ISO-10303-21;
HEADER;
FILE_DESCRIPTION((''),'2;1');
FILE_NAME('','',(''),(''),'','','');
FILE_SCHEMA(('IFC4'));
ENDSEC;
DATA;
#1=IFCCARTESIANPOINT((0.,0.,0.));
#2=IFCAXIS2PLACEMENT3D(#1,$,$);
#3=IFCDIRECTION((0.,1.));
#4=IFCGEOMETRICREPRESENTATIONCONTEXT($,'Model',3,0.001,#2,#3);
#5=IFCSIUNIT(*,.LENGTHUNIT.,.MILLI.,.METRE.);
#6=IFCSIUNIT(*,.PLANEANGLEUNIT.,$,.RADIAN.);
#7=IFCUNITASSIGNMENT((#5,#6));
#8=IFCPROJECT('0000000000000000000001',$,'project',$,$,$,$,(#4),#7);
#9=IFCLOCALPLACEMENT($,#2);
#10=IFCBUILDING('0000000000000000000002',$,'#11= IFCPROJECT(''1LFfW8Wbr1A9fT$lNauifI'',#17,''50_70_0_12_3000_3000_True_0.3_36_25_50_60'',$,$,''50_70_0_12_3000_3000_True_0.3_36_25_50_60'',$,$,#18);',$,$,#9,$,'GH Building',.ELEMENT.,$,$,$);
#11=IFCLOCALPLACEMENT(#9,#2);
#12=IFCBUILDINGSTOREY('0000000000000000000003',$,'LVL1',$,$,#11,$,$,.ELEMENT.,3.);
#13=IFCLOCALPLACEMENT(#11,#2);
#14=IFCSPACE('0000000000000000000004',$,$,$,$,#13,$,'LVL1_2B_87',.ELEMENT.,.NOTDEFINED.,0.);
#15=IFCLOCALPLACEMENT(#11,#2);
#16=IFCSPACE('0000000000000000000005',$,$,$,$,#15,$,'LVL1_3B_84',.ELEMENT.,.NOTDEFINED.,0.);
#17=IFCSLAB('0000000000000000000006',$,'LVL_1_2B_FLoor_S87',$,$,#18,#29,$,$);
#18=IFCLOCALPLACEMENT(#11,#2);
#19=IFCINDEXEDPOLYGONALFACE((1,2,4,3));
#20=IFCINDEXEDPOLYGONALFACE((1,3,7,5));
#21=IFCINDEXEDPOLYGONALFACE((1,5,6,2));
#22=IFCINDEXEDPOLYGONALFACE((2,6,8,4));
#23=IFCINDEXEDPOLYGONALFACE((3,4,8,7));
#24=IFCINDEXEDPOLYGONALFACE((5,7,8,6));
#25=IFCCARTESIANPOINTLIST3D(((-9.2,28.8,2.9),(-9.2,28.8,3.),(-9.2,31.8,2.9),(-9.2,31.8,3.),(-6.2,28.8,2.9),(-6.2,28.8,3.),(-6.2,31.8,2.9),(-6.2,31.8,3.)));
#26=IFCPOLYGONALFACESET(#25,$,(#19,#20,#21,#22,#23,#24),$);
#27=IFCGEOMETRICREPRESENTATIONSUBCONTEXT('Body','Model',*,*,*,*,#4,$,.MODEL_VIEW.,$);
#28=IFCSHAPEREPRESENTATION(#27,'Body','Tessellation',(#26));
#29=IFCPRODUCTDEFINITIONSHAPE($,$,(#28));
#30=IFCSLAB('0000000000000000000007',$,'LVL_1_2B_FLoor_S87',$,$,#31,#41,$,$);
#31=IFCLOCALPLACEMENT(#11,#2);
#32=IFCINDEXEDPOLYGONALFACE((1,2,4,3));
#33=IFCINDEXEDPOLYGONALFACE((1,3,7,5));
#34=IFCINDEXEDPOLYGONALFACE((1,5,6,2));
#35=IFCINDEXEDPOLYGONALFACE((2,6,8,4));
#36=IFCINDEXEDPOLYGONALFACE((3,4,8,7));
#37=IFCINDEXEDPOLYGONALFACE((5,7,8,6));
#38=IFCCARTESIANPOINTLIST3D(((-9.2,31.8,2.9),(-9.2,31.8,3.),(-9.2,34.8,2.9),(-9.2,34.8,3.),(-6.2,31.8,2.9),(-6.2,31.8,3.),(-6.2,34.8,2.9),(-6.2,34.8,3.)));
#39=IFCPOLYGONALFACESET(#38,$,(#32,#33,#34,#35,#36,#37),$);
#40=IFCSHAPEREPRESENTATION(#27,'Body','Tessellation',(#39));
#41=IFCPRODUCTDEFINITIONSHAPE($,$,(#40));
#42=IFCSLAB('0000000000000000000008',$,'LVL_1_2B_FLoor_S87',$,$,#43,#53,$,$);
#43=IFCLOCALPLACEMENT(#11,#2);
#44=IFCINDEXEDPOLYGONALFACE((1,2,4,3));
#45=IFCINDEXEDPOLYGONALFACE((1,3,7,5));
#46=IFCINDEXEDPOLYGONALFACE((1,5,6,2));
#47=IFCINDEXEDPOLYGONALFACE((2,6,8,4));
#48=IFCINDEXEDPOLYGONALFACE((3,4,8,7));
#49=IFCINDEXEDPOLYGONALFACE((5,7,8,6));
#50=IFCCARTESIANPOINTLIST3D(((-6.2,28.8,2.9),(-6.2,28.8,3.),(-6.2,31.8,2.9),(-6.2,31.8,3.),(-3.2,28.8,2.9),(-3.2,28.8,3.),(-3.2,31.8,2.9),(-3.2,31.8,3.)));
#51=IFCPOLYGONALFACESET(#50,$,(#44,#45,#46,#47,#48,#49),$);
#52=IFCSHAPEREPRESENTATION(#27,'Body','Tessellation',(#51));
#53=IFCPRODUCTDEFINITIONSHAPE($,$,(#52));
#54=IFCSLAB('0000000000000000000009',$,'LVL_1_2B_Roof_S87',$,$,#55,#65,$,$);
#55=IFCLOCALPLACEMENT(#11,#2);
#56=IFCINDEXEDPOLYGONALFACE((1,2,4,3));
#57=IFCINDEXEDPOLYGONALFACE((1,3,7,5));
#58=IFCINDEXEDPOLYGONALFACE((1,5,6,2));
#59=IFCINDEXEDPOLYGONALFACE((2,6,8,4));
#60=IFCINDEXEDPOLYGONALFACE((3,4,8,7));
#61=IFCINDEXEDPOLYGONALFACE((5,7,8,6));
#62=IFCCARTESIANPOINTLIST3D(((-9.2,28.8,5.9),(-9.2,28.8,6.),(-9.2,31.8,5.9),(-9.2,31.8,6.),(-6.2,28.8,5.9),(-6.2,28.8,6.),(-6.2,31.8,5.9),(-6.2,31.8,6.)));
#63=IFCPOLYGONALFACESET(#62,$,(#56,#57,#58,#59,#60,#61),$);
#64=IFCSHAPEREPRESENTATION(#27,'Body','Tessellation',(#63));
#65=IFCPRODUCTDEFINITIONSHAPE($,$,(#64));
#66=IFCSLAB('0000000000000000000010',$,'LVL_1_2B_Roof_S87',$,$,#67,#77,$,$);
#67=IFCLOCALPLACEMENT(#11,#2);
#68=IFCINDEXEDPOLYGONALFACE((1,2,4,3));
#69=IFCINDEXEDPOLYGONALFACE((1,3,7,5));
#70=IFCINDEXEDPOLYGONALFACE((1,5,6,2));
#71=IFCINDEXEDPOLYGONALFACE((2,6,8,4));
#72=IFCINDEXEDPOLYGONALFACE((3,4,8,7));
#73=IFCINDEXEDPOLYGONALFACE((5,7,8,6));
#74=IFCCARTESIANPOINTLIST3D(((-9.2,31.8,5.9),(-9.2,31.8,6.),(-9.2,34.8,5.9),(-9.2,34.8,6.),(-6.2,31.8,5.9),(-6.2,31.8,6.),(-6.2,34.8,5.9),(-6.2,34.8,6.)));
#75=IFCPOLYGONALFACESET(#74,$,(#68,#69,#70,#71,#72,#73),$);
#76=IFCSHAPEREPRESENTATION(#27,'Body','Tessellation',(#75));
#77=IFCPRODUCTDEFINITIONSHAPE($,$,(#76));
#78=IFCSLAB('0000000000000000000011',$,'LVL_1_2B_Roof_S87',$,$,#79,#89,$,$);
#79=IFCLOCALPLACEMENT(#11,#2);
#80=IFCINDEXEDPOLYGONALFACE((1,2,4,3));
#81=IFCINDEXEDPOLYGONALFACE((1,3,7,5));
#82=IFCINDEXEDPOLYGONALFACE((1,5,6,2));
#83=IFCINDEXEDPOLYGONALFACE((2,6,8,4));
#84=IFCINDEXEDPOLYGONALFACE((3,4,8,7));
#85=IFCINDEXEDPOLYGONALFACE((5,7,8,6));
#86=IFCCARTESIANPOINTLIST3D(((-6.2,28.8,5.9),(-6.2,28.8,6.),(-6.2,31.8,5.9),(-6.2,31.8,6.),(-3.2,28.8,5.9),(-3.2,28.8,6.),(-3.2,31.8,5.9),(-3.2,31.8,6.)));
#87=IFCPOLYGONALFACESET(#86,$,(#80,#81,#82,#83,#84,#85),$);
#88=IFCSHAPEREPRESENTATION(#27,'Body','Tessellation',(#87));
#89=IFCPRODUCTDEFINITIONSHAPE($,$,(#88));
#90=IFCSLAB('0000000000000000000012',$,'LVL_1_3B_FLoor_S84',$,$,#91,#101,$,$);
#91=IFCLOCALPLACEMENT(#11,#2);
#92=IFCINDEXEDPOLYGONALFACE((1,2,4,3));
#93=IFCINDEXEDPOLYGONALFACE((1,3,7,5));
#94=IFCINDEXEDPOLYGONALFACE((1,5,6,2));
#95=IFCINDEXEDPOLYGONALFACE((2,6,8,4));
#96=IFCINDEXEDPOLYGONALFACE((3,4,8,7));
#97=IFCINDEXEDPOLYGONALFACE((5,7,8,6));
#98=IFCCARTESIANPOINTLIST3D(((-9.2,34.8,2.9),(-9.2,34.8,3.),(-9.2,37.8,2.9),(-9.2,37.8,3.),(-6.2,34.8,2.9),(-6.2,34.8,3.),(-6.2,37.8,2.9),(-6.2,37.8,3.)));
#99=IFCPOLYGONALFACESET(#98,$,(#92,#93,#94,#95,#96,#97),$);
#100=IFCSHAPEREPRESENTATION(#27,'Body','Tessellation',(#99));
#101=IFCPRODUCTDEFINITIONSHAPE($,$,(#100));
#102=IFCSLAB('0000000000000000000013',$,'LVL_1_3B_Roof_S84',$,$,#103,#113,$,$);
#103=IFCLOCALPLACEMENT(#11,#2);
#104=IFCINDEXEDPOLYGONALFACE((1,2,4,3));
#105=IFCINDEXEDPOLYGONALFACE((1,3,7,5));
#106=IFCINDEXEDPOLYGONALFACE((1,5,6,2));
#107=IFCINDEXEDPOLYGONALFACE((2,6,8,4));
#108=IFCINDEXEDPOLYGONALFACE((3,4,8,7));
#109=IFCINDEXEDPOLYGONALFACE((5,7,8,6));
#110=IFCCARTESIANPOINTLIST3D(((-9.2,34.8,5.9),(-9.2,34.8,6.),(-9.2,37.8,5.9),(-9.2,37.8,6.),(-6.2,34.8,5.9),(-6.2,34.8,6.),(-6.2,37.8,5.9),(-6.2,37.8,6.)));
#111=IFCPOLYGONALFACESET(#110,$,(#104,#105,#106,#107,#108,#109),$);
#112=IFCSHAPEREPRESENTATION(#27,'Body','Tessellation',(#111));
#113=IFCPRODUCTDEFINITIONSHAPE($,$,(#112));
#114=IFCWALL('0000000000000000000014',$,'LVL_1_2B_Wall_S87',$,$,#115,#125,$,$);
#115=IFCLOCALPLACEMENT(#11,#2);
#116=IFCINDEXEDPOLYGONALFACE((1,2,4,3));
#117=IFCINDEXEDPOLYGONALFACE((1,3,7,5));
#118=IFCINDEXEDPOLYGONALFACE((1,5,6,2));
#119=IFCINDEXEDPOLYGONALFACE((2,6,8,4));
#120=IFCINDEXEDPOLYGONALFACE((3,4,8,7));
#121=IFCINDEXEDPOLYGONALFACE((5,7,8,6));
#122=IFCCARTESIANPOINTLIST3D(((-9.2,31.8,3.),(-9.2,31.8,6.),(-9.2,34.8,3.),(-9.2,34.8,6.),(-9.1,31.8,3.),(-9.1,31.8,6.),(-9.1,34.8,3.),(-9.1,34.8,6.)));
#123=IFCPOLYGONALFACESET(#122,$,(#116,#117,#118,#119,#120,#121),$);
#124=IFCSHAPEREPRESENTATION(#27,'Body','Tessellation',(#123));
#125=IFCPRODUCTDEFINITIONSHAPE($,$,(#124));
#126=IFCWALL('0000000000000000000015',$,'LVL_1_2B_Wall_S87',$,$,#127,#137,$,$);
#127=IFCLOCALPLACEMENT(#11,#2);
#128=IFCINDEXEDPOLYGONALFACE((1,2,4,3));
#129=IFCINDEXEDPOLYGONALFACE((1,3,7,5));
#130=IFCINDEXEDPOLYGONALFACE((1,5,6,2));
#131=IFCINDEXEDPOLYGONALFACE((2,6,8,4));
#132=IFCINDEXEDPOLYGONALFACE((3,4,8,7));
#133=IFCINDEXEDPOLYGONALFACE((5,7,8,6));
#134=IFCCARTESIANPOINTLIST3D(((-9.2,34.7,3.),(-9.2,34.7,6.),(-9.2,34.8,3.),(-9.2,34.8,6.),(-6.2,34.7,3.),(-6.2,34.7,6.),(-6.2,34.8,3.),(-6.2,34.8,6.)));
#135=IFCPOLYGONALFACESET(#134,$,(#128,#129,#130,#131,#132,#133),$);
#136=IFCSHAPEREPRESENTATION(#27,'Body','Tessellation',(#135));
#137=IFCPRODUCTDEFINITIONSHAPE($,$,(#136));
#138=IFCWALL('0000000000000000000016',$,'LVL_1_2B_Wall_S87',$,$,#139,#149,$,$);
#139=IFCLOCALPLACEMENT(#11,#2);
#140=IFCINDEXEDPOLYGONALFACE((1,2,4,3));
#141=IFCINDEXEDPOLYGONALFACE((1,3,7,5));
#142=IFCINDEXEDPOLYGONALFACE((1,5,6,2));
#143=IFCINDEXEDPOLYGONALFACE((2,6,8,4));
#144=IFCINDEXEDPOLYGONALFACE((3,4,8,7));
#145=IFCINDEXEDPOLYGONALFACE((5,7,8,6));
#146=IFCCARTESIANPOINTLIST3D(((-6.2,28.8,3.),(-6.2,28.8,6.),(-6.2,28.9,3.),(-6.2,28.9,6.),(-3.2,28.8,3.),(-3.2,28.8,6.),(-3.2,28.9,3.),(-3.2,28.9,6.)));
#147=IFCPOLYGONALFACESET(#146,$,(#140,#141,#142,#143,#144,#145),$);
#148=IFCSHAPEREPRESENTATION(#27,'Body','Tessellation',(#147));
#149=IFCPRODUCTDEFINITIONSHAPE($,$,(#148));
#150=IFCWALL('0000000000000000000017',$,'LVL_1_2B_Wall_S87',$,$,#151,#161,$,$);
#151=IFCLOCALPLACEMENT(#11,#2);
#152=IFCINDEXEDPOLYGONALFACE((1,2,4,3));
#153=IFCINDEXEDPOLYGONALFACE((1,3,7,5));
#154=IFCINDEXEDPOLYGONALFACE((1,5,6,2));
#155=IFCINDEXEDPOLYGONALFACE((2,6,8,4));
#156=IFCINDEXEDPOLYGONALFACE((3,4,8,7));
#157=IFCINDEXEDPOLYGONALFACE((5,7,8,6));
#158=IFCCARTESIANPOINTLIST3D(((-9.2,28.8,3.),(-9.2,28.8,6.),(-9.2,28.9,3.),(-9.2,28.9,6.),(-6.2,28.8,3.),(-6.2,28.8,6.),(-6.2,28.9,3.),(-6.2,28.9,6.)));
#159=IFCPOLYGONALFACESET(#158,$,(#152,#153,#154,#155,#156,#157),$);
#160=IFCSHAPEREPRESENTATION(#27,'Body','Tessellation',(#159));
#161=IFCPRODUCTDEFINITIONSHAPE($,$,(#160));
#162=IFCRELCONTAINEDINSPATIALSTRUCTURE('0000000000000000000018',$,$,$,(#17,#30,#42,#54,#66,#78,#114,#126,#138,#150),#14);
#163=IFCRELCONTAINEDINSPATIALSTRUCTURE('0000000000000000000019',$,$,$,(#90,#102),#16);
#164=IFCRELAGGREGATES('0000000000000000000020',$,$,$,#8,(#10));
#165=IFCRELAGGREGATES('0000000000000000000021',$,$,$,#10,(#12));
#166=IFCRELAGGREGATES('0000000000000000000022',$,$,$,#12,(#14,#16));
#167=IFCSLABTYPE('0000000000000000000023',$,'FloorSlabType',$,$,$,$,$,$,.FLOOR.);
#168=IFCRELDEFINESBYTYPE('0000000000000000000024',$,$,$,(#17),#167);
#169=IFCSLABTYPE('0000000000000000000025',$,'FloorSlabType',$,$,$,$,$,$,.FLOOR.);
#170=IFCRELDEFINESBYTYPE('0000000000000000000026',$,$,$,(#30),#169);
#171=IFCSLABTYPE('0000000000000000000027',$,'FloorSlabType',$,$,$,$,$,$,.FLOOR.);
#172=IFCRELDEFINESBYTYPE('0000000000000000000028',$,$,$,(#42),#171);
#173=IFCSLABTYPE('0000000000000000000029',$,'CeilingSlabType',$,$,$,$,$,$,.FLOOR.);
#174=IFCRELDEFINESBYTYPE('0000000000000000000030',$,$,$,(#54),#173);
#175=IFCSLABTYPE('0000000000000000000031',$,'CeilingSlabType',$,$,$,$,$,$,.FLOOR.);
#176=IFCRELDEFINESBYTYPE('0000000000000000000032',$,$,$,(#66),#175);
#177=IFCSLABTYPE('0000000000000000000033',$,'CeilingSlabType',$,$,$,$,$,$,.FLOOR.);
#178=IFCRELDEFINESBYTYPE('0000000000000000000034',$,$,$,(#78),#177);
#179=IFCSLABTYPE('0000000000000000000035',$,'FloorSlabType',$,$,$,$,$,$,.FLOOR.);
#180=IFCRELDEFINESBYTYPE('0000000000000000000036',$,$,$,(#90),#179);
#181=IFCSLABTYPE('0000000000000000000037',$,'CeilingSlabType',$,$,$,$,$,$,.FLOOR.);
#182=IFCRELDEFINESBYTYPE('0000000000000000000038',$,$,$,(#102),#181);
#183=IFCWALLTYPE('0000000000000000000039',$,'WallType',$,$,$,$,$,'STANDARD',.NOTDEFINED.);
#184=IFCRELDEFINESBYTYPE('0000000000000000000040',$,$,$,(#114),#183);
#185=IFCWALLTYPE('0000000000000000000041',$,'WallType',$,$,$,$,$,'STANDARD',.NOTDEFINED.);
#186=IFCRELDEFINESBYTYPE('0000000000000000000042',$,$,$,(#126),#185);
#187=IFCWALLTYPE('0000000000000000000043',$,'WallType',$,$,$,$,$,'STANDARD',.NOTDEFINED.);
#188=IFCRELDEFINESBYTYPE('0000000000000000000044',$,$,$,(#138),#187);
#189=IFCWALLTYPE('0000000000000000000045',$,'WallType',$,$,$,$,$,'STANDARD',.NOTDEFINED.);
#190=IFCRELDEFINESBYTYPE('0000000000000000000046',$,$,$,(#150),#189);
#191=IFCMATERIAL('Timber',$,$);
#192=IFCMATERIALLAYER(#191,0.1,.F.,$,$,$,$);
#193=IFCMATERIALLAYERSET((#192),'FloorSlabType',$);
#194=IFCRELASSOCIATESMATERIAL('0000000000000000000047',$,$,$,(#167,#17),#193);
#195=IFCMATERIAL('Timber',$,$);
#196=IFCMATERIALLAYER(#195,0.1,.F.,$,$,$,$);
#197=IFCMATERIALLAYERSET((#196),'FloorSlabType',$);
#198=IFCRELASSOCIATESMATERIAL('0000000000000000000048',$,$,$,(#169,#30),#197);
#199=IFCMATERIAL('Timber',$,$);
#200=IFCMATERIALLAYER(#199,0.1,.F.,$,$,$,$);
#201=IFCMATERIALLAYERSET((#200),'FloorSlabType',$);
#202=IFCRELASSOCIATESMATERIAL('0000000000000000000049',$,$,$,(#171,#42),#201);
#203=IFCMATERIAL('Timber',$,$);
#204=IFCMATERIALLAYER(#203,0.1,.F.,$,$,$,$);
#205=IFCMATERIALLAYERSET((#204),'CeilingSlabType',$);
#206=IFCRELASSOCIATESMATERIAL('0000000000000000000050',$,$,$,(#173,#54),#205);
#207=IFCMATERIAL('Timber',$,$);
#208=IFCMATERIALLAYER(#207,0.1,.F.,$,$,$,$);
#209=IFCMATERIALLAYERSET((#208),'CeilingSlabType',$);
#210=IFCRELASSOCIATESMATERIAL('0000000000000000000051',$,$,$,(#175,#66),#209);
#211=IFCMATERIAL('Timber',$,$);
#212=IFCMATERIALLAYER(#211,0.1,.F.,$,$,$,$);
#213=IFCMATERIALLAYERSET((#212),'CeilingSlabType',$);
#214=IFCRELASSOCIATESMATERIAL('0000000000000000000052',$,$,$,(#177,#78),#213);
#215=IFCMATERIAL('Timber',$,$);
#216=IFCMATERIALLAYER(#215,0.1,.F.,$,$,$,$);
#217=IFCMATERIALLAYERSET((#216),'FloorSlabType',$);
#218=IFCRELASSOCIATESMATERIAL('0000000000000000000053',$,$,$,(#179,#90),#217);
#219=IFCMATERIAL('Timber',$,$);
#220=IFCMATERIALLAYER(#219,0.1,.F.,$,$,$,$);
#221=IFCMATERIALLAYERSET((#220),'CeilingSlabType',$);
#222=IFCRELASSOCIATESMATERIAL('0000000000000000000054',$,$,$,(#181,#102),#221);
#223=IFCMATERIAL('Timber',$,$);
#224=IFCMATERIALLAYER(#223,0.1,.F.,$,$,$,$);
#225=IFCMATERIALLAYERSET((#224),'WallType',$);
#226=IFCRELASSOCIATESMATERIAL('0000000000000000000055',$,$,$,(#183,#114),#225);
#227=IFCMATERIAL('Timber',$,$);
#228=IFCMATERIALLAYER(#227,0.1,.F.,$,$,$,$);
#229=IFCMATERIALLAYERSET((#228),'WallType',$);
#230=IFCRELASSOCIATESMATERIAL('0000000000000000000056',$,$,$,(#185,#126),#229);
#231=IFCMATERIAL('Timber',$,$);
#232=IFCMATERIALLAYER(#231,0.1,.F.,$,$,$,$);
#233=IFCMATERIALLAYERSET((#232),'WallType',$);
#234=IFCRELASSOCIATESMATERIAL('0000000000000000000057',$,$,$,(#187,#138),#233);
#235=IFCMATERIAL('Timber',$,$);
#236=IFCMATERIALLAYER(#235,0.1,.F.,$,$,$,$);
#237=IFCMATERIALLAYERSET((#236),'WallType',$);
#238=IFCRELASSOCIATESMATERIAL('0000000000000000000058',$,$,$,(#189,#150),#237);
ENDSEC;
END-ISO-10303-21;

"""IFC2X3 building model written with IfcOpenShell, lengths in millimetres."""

from ifc_helpers import new_model, si_unit, direction, frame, frame_2d, origin, place, context, subcontext, project, spatial, rectangle, extrude, material, layer, layer_set, layer_usage, type_object, element, save


model = new_model("IFC2X3")

# Units and contexts
model_context = context("Model", 3, precision=0.001, world=origin(), true_north=direction((0.0, 1.0)))
body_context = subcontext(model_context, "Body", "Model", "MODEL_VIEW")
ifc_project = project(units=[si_unit("LENGTHUNIT", "METRE", prefix="MILLI"), si_unit("PLANEANGLEUNIT", "RADIAN")], contexts=[model_context])

# Building, storey
building_placement = place(None, origin())
building = spatial("IfcBuilding", under=ifc_project, at=building_placement, Name="#11= IFCPROJECT('1LFfW8Wbr1A9fT$lNauifI',#17,'50_70_0_12_3000_3000_True_0.3_36_25_50_60',$,$,'50_70_0_12_3000_3000_True_0.3_36_25_50_60',$,$,#18);", LongName="GH Building", CompositionType="ELEMENT")
storey_placement = place(building_placement, origin())
storey = spatial("IfcBuildingStorey", under=building, at=storey_placement, Name="LVL1", CompositionType="ELEMENT", Elevation=3.0)

# Shared definitions
space_1_placement = place(storey_placement, origin())
space_1 = spatial("IfcSpace", under=storey, at=space_1_placement, LongName="LVL1_2B_87", CompositionType="ELEMENT", InteriorOrExteriorSpace="NOTDEFINED", ElevationWithFlooring=0.0)

# Slabs
ifc_material_1 = material(Name="Timber")
ifc_layer_1 = layer(ifc_material_1, 0.1, ventilated=False)
ifc_layer_set_1 = layer_set([ifc_layer_1], Name="FloorSlabType")
ifc_layer_usage_1 = layer_usage(ifc_layer_set_1, "AXIS3", "NEGATIVE", -0.1)
slab_type_1 = type_object("IfcSlabType", Name="FloorSlabType", PredefinedType="FLOOR", material=ifc_layer_set_1)
slab_1_placement = place(space_1_placement, frame((-6.2, 28.8, 2.9), z_axis=(0.0, 0.0, 1.0), x_axis=(0.0, 1.0, 0.0)))
element("IfcSlab", 1, at=slab_1_placement, inside=space_1, type_object=slab_type_1, material=ifc_layer_usage_1, Name="LVL_1_2B_FLoor_S87", context=body_context, shape_type="SweptSolid", body=[
    extrude(rectangle(XDim=3.0, YDim=3.0, at=frame_2d((1.5, 1.5))), origin(), (0.0, 0.0, 1.0), 0.1),
])
ifc_material_2 = material(Name="Timber")
ifc_layer_2 = layer(ifc_material_2, 0.1, ventilated=False)
ifc_layer_set_2 = layer_set([ifc_layer_2], Name="FloorSlabType")
ifc_layer_usage_2 = layer_usage(ifc_layer_set_2, "AXIS3", "NEGATIVE", -0.1)
slab_type_2 = type_object("IfcSlabType", Name="FloorSlabType", PredefinedType="FLOOR", material=ifc_layer_set_2)
slab_2_placement = place(space_1_placement, frame((-6.2, 31.8, 2.9), z_axis=(0.0, 0.0, 1.0), x_axis=(0.0, 1.0, 0.0)))
element("IfcSlab", 2, at=slab_2_placement, inside=space_1, type_object=slab_type_2, material=ifc_layer_usage_2, Name="LVL_1_2B_FLoor_S87", context=body_context, shape_type="SweptSolid", body=[
    extrude(rectangle(XDim=3.0, YDim=3.0, at=frame_2d((1.5, 1.5))), origin(), (0.0, 0.0, 1.0), 0.1),
])
ifc_material_3 = material(Name="Timber")
ifc_layer_3 = layer(ifc_material_3, 0.1, ventilated=False)
ifc_layer_set_3 = layer_set([ifc_layer_3], Name="FloorSlabType")
ifc_layer_usage_3 = layer_usage(ifc_layer_set_3, "AXIS3", "NEGATIVE", -0.1)
slab_type_3 = type_object("IfcSlabType", Name="FloorSlabType", PredefinedType="FLOOR", material=ifc_layer_set_3)
slab_3_placement = place(space_1_placement, frame((-3.2, 28.8, 2.9), z_axis=(0.0, 0.0, 1.0), x_axis=(0.0, 1.0, 0.0)))
element("IfcSlab", 3, at=slab_3_placement, inside=space_1, type_object=slab_type_3, material=ifc_layer_usage_3, Name="LVL_1_2B_FLoor_S87", context=body_context, shape_type="SweptSolid", body=[
    extrude(rectangle(XDim=3.0, YDim=3.0, at=frame_2d((1.5, 1.5))), origin(), (0.0, 0.0, 1.0), 0.1),
])
ifc_material_4 = material(Name="Timber")
ifc_layer_4 = layer(ifc_material_4, 0.1, ventilated=False)
ifc_layer_set_4 = layer_set([ifc_layer_4], Name="CeilingSlabType")
ifc_layer_usage_4 = layer_usage(ifc_layer_set_4, "AXIS3", "NEGATIVE", -0.1)
slab_type_4 = type_object("IfcSlabType", Name="CeilingSlabType", PredefinedType="FLOOR", material=ifc_layer_set_4)
slab_4_placement = place(space_1_placement, frame((-6.2, 28.8, 5.9), z_axis=(0.0, 0.0, 1.0), x_axis=(0.0, 1.0, 0.0)))
element("IfcSlab", 4, at=slab_4_placement, inside=space_1, type_object=slab_type_4, material=ifc_layer_usage_4, Name="LVL_1_2B_Roof_S87", context=body_context, shape_type="SweptSolid", body=[
    extrude(rectangle(XDim=3.0, YDim=3.0, at=frame_2d((1.5, 1.5))), origin(), (0.0, 0.0, 1.0), 0.1),
])
ifc_material_5 = material(Name="Timber")
ifc_layer_5 = layer(ifc_material_5, 0.1, ventilated=False)
ifc_layer_set_5 = layer_set([ifc_layer_5], Name="CeilingSlabType")
ifc_layer_usage_5 = layer_usage(ifc_layer_set_5, "AXIS3", "NEGATIVE", -0.1)
slab_type_5 = type_object("IfcSlabType", Name="CeilingSlabType", PredefinedType="FLOOR", material=ifc_layer_set_5)
slab_5_placement = place(space_1_placement, frame((-6.2, 31.8, 5.9), z_axis=(0.0, 0.0, 1.0), x_axis=(0.0, 1.0, 0.0)))
element("IfcSlab", 5, at=slab_5_placement, inside=space_1, type_object=slab_type_5, material=ifc_layer_usage_5, Name="LVL_1_2B_Roof_S87", context=body_context, shape_type="SweptSolid", body=[
    extrude(rectangle(XDim=3.0, YDim=3.0, at=frame_2d((1.5, 1.5))), origin(), (0.0, 0.0, 1.0), 0.1),
])
ifc_material_6 = material(Name="Timber")
ifc_layer_6 = layer(ifc_material_6, 0.1, ventilated=False)
ifc_layer_set_6 = layer_set([ifc_layer_6], Name="CeilingSlabType")
ifc_layer_usage_6 = layer_usage(ifc_layer_set_6, "AXIS3", "NEGATIVE", -0.1)
slab_type_6 = type_object("IfcSlabType", Name="CeilingSlabType", PredefinedType="FLOOR", material=ifc_layer_set_6)
slab_6_placement = place(space_1_placement, frame((-3.2, 28.8, 5.9), z_axis=(0.0, 0.0, 1.0), x_axis=(0.0, 1.0, 0.0)))
element("IfcSlab", 6, at=slab_6_placement, inside=space_1, type_object=slab_type_6, material=ifc_layer_usage_6, Name="LVL_1_2B_Roof_S87", context=body_context, shape_type="SweptSolid", body=[
    extrude(rectangle(XDim=3.0, YDim=3.0, at=frame_2d((1.5, 1.5))), origin(), (0.0, 0.0, 1.0), 0.1),
])

# Shared definitions
space_2_placement = place(storey_placement, origin())
space_2 = spatial("IfcSpace", under=storey, at=space_2_placement, LongName="LVL1_3B_84", CompositionType="ELEMENT", InteriorOrExteriorSpace="NOTDEFINED", ElevationWithFlooring=0.0)

# Slabs
ifc_material_7 = material(Name="Timber")
ifc_layer_7 = layer(ifc_material_7, 0.1, ventilated=False)
ifc_layer_set_7 = layer_set([ifc_layer_7], Name="FloorSlabType")
ifc_layer_usage_7 = layer_usage(ifc_layer_set_7, "AXIS3", "NEGATIVE", -0.1)
slab_type_7 = type_object("IfcSlabType", Name="FloorSlabType", PredefinedType="FLOOR", material=ifc_layer_set_7)
slab_7_placement = place(space_2_placement, frame((-6.2, 34.8, 2.9), z_axis=(0.0, 0.0, 1.0), x_axis=(0.0, 1.0, 0.0)))
element("IfcSlab", 7, at=slab_7_placement, inside=space_2, type_object=slab_type_7, material=ifc_layer_usage_7, Name="LVL_1_3B_FLoor_S84", context=body_context, shape_type="SweptSolid", body=[
    extrude(rectangle(XDim=3.0, YDim=3.0, at=frame_2d((1.5, 1.5))), origin(), (0.0, 0.0, 1.0), 0.1),
])
ifc_material_8 = material(Name="Timber")
ifc_layer_8 = layer(ifc_material_8, 0.1, ventilated=False)
ifc_layer_set_8 = layer_set([ifc_layer_8], Name="CeilingSlabType")
ifc_layer_usage_8 = layer_usage(ifc_layer_set_8, "AXIS3", "NEGATIVE", -0.1)
slab_type_8 = type_object("IfcSlabType", Name="CeilingSlabType", PredefinedType="FLOOR", material=ifc_layer_set_8)
slab_8_placement = place(space_2_placement, frame((-6.2, 34.8, 5.9), z_axis=(0.0, 0.0, 1.0), x_axis=(0.0, 1.0, 0.0)))
element("IfcSlab", 8, at=slab_8_placement, inside=space_2, type_object=slab_type_8, material=ifc_layer_usage_8, Name="LVL_1_3B_Roof_S84", context=body_context, shape_type="SweptSolid", body=[
    extrude(rectangle(XDim=3.0, YDim=3.0, at=frame_2d((1.5, 1.5))), origin(), (0.0, 0.0, 1.0), 0.1),
])

# Walls
ifc_material_9 = material(Name="Timber")
ifc_layer_9 = layer(ifc_material_9, 0.1, ventilated=False)
ifc_layer_set_9 = layer_set([ifc_layer_9], Name="WallType")
ifc_layer_usage_9 = layer_usage(ifc_layer_set_9, "AXIS2", "NEGATIVE", 0.0)
wall_type_1 = type_object("IfcWallType", Name="WallType", ElementType="STANDARD", PredefinedType="NOTDEFINED", material=ifc_layer_set_9)
wall_1_placement = place(space_1_placement, frame((-9.2, 31.8, 3.0), z_axis=(0.0, 0.0, 1.0), x_axis=(0.0, 1.0, 0.0)))
element("IfcWall", 9, at=wall_1_placement, inside=space_1, type_object=wall_type_1, material=ifc_layer_usage_9, Name="LVL_1_2B_Wall_S87", context=body_context, shape_type="SweptSolid", body=[
    extrude(rectangle(XDim=3.0, YDim=0.1, at=frame_2d((1.5, -0.1))), origin(), (0.0, 0.0, 1.0), 3.0),
])
ifc_material_10 = material(Name="Timber")
ifc_layer_10 = layer(ifc_material_10, 0.1, ventilated=False)
ifc_layer_set_10 = layer_set([ifc_layer_10], Name="WallType")
ifc_layer_usage_10 = layer_usage(ifc_layer_set_10, "AXIS2", "NEGATIVE", 0.0)
wall_type_2 = type_object("IfcWallType", Name="WallType", ElementType="STANDARD", PredefinedType="NOTDEFINED", material=ifc_layer_set_10)
wall_2_placement = place(space_1_placement, frame((-9.2, 34.8, 3.0)))
element("IfcWall", 10, at=wall_2_placement, inside=space_1, type_object=wall_type_2, material=ifc_layer_usage_10, Name="LVL_1_2B_Wall_S87", context=body_context, shape_type="SweptSolid", body=[
    extrude(rectangle(XDim=3.0, YDim=0.1, at=frame_2d((1.5, -0.1))), origin(), (0.0, 0.0, 1.0), 3.0),
])
ifc_material_11 = material(Name="Timber")
ifc_layer_11 = layer(ifc_material_11, 0.1, ventilated=False)
ifc_layer_set_11 = layer_set([ifc_layer_11], Name="WallType")
ifc_layer_usage_11 = layer_usage(ifc_layer_set_11, "AXIS2", "NEGATIVE", 0.0)
wall_type_3 = type_object("IfcWallType", Name="WallType", ElementType="STANDARD", PredefinedType="NOTDEFINED", material=ifc_layer_set_11)
wall_3_placement = place(space_1_placement, frame((-3.2, 28.8, 3.0), z_axis=(0.0, 0.0, 1.0), x_axis=(-1.0, 0.0, 0.0)))
element("IfcWall", 11, at=wall_3_placement, inside=space_1, type_object=wall_type_3, material=ifc_layer_usage_11, Name="LVL_1_2B_Wall_S87", context=body_context, shape_type="SweptSolid", body=[
    extrude(rectangle(XDim=3.0, YDim=0.1, at=frame_2d((1.5, -0.1))), origin(), (0.0, 0.0, 1.0), 3.0),
])
ifc_material_12 = material(Name="Timber")
ifc_layer_12 = layer(ifc_material_12, 0.1, ventilated=False)
ifc_layer_set_12 = layer_set([ifc_layer_12], Name="WallType")
ifc_layer_usage_12 = layer_usage(ifc_layer_set_12, "AXIS2", "NEGATIVE", 0.0)
wall_type_4 = type_object("IfcWallType", Name="WallType", ElementType="STANDARD", PredefinedType="NOTDEFINED", material=ifc_layer_set_12)
wall_4_placement = place(space_1_placement, frame((-6.2, 28.8, 3.0), z_axis=(0.0, 0.0, 1.0), x_axis=(-1.0, 0.0, 0.0)))
element("IfcWall", 12, at=wall_4_placement, inside=space_1, type_object=wall_type_4, material=ifc_layer_usage_12, Name="LVL_1_2B_Wall_S87", context=body_context, shape_type="SweptSolid", body=[
    extrude(rectangle(XDim=3.0, YDim=0.1, at=frame_2d((1.5, -0.1))), origin(), (0.0, 0.0, 1.0), 3.0),
])

save(model, "model.ifc")
